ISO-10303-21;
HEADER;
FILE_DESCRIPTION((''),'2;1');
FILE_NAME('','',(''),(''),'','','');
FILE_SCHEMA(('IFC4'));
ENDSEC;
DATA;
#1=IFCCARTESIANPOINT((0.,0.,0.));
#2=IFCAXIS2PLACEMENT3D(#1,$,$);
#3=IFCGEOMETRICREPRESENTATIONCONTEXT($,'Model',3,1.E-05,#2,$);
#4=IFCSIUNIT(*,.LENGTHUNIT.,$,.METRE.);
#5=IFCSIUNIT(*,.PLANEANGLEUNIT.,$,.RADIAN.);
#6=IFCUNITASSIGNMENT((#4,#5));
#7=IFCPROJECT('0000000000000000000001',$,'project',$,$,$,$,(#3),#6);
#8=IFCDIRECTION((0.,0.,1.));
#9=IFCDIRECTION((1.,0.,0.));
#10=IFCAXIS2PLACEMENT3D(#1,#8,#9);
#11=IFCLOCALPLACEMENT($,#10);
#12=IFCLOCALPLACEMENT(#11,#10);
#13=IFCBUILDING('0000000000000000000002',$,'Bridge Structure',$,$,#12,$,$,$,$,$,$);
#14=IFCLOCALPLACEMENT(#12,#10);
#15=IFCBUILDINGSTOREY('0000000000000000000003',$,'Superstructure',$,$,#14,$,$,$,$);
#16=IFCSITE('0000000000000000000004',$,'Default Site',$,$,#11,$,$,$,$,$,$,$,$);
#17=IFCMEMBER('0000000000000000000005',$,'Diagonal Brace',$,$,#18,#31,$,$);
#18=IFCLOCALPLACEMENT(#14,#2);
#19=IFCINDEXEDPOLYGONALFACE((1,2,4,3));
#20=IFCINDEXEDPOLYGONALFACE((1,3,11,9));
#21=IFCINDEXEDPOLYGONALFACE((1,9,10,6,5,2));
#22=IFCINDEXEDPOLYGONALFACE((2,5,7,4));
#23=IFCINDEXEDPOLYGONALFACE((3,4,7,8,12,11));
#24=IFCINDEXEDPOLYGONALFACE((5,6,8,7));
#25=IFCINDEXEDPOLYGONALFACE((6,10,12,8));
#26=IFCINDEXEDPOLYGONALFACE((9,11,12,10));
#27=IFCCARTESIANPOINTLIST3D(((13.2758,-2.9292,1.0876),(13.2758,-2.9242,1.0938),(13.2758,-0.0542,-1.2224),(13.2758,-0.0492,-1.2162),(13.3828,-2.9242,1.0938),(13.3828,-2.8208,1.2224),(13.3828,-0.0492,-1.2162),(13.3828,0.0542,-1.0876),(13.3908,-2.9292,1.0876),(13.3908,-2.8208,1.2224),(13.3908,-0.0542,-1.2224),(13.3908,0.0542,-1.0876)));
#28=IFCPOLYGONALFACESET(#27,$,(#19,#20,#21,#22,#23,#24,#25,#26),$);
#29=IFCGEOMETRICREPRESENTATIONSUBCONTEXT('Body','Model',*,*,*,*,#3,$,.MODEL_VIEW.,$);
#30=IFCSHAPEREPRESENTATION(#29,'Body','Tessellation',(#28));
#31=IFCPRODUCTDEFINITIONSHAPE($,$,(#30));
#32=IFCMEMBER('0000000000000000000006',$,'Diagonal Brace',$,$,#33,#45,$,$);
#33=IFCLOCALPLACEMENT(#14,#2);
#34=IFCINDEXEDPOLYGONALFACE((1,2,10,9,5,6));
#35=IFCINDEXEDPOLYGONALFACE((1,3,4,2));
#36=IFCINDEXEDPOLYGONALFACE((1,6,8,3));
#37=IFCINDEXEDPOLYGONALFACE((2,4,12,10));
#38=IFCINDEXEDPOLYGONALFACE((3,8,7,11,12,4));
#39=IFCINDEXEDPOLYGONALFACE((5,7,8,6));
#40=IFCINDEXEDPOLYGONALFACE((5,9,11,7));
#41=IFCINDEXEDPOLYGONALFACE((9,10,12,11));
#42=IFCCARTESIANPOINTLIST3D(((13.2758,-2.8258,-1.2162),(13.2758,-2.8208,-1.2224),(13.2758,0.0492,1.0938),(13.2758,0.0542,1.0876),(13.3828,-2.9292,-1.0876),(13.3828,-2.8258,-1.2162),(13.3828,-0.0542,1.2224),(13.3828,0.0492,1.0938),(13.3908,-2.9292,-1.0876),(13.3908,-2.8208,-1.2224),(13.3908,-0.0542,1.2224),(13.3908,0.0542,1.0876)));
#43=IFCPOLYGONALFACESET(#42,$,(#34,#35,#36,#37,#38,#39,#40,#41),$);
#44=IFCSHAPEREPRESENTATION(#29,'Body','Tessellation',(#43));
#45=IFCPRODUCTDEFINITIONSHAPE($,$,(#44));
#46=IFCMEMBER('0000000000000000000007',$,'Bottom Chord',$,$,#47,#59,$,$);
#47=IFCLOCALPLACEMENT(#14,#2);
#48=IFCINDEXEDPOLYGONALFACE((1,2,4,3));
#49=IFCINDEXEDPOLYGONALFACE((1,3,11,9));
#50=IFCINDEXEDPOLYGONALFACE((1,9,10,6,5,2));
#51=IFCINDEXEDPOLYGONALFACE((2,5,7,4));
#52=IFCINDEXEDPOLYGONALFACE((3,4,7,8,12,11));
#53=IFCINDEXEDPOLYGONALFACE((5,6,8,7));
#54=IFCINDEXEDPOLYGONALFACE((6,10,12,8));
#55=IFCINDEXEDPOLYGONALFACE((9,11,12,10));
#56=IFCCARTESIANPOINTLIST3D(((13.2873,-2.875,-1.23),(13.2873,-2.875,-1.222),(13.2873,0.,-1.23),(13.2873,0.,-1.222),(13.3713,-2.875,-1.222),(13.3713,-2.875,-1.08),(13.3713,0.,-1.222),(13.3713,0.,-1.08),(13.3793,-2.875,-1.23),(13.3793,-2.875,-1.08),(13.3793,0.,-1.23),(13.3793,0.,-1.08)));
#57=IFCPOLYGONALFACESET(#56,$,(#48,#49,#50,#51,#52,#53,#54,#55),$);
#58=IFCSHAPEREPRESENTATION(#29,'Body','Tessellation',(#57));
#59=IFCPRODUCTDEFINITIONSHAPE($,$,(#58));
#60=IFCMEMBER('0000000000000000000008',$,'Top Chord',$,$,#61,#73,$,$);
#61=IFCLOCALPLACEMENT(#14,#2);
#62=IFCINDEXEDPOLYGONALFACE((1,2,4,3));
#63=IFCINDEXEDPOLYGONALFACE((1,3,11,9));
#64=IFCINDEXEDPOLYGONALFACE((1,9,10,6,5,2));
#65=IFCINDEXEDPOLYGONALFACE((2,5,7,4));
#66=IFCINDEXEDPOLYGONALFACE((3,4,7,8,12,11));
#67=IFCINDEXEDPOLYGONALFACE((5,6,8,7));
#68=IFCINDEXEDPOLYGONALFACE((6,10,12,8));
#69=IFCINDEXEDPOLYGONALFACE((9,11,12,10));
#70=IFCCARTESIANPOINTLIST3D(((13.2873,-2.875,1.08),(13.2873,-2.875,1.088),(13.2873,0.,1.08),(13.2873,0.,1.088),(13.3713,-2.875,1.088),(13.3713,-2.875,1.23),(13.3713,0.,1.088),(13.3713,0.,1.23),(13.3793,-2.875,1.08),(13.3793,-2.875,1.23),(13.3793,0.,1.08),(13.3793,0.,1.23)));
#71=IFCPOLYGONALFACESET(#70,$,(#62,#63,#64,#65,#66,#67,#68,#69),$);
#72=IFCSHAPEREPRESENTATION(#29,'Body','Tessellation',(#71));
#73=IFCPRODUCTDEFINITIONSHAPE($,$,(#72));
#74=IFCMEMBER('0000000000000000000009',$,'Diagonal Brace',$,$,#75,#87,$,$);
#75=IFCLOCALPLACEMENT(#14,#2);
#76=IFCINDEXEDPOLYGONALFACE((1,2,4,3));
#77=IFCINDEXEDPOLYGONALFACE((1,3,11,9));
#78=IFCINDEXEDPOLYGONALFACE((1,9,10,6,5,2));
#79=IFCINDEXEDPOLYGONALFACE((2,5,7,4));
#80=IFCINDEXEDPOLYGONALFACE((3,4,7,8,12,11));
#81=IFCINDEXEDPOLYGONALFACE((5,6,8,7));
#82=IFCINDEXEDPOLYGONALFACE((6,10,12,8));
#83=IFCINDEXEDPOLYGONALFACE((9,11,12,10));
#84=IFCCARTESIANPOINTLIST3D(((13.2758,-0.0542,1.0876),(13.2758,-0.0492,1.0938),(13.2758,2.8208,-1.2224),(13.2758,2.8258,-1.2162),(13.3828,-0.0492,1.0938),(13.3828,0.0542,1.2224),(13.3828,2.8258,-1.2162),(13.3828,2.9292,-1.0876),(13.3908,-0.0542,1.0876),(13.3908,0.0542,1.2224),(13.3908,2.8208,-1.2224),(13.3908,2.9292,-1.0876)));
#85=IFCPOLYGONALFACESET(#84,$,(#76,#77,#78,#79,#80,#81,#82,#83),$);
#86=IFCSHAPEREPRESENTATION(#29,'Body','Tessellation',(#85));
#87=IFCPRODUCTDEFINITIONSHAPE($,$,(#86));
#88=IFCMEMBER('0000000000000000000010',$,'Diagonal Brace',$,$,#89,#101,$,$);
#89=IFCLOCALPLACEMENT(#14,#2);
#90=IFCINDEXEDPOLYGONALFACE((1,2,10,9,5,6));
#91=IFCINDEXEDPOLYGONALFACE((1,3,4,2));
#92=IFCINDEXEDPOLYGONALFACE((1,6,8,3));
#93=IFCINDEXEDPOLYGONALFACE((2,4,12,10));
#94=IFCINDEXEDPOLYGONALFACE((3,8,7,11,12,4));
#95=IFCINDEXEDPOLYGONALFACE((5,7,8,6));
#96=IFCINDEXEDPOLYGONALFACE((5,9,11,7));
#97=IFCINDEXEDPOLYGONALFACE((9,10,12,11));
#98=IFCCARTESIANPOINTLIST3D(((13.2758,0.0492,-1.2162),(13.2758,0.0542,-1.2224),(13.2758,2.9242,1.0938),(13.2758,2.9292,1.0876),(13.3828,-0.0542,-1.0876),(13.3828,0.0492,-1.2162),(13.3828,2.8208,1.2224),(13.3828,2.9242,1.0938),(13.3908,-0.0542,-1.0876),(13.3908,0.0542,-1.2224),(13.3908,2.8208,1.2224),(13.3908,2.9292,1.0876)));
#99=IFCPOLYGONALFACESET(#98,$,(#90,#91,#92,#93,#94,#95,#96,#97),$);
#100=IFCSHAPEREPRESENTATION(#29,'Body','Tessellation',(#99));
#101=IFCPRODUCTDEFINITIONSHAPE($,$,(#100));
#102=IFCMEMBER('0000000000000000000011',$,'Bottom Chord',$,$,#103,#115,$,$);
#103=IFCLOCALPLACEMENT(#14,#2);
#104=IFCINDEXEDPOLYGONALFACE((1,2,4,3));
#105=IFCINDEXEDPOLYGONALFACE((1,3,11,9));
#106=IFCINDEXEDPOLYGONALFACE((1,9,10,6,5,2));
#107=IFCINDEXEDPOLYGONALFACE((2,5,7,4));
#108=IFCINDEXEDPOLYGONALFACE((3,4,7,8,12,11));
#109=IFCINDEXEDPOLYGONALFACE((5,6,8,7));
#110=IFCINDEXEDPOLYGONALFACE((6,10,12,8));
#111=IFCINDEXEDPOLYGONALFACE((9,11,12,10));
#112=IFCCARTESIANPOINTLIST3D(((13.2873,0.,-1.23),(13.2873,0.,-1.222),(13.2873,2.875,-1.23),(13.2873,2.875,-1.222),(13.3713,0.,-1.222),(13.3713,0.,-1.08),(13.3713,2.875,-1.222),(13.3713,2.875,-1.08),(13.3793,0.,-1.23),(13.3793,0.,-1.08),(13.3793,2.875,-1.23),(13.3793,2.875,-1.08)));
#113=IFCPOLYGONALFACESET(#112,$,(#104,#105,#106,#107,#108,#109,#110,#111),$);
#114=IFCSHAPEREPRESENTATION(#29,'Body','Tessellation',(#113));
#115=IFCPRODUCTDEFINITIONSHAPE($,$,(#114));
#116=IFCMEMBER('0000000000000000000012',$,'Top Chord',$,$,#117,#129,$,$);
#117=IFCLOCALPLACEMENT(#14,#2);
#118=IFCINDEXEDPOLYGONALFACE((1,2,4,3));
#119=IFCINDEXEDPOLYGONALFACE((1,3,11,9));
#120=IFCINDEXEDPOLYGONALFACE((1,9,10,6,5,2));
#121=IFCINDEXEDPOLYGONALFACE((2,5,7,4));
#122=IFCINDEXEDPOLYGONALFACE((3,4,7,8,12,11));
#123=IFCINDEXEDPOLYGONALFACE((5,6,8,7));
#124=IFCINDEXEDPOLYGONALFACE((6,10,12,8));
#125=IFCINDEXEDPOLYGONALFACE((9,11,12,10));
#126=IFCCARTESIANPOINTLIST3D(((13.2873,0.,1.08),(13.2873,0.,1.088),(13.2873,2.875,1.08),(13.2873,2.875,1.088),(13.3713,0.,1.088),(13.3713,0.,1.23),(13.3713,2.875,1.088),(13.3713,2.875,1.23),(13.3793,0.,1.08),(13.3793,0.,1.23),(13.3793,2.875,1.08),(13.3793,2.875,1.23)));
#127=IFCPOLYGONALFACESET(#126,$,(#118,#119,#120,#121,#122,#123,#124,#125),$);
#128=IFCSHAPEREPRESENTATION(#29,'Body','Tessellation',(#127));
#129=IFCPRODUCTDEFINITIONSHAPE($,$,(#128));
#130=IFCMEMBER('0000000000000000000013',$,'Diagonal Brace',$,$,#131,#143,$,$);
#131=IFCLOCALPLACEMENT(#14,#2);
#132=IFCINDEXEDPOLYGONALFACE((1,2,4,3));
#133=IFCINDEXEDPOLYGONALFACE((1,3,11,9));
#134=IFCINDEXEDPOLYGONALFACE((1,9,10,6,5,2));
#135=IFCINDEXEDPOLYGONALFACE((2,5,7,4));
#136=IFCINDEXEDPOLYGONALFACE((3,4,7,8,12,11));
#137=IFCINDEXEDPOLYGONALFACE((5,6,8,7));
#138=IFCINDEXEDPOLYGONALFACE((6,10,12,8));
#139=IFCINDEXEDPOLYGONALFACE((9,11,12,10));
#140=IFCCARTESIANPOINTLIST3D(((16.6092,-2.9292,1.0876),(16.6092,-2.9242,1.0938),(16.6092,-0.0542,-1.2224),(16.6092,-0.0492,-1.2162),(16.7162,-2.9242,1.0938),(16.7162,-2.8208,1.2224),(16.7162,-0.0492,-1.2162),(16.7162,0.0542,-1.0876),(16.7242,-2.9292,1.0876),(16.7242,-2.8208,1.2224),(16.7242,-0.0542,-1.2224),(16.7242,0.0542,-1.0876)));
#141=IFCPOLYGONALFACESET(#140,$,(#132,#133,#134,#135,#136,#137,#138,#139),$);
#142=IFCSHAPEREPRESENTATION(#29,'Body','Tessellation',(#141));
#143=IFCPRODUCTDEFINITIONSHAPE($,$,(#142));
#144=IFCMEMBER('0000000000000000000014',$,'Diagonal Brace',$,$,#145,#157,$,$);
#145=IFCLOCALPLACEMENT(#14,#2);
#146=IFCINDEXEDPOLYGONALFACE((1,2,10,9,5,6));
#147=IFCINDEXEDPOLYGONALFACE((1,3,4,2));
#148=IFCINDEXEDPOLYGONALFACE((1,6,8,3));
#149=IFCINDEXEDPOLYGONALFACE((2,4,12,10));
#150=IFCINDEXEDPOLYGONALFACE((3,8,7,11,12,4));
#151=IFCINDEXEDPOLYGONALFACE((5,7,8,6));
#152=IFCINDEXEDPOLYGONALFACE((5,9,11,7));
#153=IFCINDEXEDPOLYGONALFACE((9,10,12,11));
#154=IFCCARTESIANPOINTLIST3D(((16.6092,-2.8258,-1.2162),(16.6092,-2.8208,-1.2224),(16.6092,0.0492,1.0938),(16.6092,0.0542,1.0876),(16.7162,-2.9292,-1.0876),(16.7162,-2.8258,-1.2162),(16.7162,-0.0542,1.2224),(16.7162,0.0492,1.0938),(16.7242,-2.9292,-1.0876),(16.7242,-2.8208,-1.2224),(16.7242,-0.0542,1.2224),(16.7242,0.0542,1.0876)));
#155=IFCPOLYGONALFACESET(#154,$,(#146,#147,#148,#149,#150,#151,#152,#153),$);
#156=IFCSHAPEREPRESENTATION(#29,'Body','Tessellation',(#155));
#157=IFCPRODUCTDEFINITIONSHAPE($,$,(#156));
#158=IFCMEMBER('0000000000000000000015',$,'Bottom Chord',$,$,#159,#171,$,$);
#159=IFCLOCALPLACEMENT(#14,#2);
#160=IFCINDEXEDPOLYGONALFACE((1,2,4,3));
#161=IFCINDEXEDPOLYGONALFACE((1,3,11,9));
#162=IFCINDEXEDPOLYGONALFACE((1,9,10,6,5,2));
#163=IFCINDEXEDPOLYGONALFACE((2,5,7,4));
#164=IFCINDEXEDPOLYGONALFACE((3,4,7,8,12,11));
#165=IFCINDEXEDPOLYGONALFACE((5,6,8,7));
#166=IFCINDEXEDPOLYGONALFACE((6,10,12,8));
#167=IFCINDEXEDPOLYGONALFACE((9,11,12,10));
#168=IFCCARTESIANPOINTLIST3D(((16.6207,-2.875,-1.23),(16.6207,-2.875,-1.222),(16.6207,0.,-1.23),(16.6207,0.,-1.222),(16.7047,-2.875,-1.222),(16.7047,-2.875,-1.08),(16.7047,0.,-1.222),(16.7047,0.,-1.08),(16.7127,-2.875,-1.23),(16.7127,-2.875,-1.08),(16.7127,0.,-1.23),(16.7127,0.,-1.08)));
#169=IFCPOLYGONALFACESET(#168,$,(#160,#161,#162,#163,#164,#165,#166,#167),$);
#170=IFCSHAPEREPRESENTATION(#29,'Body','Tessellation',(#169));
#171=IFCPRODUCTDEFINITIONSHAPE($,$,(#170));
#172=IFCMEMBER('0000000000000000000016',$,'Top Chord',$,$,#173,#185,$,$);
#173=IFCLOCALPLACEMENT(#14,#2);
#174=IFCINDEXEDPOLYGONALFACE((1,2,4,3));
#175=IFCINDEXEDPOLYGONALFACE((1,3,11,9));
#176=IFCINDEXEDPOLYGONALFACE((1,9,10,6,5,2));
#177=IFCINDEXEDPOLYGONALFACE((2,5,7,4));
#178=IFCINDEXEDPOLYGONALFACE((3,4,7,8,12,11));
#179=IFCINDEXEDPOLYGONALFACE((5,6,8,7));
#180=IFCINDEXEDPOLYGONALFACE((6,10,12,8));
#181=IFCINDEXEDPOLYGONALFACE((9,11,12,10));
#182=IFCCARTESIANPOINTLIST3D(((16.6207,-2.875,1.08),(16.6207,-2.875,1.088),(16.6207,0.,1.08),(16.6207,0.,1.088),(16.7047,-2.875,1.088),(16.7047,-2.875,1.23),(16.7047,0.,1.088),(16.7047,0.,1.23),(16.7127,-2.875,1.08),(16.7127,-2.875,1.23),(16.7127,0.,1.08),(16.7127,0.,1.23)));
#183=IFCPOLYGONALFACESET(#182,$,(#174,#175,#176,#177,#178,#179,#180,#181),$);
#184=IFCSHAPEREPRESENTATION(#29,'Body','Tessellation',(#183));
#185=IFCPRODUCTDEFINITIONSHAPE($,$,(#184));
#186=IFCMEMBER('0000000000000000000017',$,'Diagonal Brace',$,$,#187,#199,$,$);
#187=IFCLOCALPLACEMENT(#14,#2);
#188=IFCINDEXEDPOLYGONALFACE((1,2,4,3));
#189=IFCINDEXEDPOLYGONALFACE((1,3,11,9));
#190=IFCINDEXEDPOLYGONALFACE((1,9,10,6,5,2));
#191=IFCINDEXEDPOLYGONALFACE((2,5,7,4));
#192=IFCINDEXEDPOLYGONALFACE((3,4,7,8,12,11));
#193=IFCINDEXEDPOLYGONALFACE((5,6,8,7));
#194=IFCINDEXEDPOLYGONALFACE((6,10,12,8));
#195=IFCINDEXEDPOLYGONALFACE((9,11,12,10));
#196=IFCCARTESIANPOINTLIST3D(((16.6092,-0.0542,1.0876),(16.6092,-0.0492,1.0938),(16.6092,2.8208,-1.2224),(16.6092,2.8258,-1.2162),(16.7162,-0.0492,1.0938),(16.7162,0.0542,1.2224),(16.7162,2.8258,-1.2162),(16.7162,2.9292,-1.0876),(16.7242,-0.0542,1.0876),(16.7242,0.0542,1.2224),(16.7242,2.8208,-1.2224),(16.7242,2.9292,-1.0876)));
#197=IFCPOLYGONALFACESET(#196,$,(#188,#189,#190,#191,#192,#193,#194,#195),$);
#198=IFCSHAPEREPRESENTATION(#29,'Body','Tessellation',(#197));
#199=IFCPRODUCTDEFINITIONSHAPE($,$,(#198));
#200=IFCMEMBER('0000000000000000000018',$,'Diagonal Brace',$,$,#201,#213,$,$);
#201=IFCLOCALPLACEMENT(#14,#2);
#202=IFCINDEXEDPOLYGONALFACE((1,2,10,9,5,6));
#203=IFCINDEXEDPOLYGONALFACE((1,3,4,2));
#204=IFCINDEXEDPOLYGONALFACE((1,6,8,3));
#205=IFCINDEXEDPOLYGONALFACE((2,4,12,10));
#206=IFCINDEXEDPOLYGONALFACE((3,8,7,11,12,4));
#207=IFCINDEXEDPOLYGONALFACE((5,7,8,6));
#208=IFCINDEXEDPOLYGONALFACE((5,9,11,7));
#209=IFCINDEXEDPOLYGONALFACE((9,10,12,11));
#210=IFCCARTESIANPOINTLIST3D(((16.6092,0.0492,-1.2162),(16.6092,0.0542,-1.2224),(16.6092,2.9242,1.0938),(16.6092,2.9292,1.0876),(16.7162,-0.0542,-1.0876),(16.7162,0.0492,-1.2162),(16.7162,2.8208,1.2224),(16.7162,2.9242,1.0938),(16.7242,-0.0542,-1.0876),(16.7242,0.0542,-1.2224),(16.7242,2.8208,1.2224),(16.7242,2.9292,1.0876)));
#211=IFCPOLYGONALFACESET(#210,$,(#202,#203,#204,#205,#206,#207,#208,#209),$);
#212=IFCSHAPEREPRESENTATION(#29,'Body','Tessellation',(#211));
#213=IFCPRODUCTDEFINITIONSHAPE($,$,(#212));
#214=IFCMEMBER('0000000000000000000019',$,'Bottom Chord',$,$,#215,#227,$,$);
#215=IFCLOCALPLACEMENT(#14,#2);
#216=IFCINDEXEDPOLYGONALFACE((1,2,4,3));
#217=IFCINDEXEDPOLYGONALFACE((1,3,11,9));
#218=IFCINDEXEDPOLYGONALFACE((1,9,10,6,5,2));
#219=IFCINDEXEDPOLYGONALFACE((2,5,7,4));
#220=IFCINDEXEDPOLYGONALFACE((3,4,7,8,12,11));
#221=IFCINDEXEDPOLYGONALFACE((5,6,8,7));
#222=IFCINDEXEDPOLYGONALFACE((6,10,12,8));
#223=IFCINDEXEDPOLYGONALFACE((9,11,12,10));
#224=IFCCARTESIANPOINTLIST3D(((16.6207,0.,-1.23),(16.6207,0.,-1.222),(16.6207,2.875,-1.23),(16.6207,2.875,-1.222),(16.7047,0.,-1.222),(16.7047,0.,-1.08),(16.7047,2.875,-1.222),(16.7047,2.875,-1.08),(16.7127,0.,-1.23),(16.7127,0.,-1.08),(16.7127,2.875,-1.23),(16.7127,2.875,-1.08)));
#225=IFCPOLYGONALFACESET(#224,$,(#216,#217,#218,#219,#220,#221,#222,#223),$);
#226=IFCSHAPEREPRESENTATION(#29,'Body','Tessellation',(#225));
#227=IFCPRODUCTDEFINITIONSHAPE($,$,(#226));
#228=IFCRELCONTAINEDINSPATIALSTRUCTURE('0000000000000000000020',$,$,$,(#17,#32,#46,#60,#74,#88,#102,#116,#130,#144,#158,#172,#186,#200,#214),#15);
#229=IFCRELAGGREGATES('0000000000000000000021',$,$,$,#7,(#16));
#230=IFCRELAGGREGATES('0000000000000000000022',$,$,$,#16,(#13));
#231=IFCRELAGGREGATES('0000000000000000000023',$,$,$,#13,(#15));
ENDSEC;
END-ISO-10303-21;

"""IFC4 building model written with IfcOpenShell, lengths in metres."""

from ifc_helpers import new_model, si_unit, frame, origin, origin_with_axes, origin_2d_with_axis, place, context, subcontext, project, spatial, l_section, extrude, element, save


model = new_model("IFC4")

# Units and contexts
model_context = context("Model", 3, precision=1e-05, world=origin())
body_context = subcontext(model_context, "Body", "Model", "MODEL_VIEW")
ifc_project = project(units=[si_unit("LENGTHUNIT", "METRE"), si_unit("PLANEANGLEUNIT", "RADIAN")], contexts=[model_context])

# Site, building, storey
site_placement = place(None, origin_with_axes())
site = spatial("IfcSite", under=ifc_project, at=site_placement, Name="Default Site")
building_placement = place(site_placement, origin_with_axes())
building = spatial("IfcBuilding", under=site, at=building_placement, Name="Bridge Structure")
storey_placement = place(building_placement, origin_with_axes())
storey = spatial("IfcBuildingStorey", under=building, at=storey_placement, Name="Superstructure")

# Members
for number, where, z_axis, x_axis, name in (
    (1, (13.3333, -2.875, 1.155), (0.0, 0.779544, -0.626347), (-1.0, 0.0, 0.0), "Diagonal Brace"),
    (2, (13.3333, -2.875, -1.155), (0.0, 0.779544, 0.626347), (-1.0, 0.0, 0.0), "Diagonal Brace"),
):
    element("IfcMember", number, at=place(storey_placement, frame(where, z_axis=z_axis, x_axis=x_axis)), inside=storey, Name=name, context=body_context, shape_type="SweptSolid", body=[
        extrude(l_section(Depth=0.173, Width=0.115, Thickness=0.008, at=origin_2d_with_axis()), origin_with_axes(), (0.0, 0.0, 1.0), 3.6881),
    ])
for number, where, z_axis, x_axis, name in (
    (3, (13.3333, -2.875, -1.155), (0.0, 1.0, 0.0), (-1.0, 0.0, 0.0), "Bottom Chord"),
    (4, (13.3333, -2.875, 1.155), (0.0, 1.0, 0.0), (-1.0, 0.0, 0.0), "Top Chord"),
):
    element("IfcMember", number, at=place(storey_placement, frame(where, z_axis=z_axis, x_axis=x_axis)), inside=storey, Name=name, context=body_context, shape_type="SweptSolid", body=[
        extrude(l_section(Depth=0.15, Width=0.092, Thickness=0.008, at=origin_2d_with_axis()), origin_with_axes(), (0.0, 0.0, 1.0), 2.875),
    ])
for number, where, z_axis, x_axis, name in (
    (5, (13.3333, 0.0, 1.155), (0.0, 0.779544, -0.626347), (-1.0, 0.0, 0.0), "Diagonal Brace"),
    (6, (13.3333, 0.0, -1.155), (0.0, 0.779544, 0.626347), (-1.0, 0.0, 0.0), "Diagonal Brace"),
):
    element("IfcMember", number, at=place(storey_placement, frame(where, z_axis=z_axis, x_axis=x_axis)), inside=storey, Name=name, context=body_context, shape_type="SweptSolid", body=[
        extrude(l_section(Depth=0.173, Width=0.115, Thickness=0.008, at=origin_2d_with_axis()), origin_with_axes(), (0.0, 0.0, 1.0), 3.6881),
    ])
for number, where, z_axis, x_axis, name in (
    (7, (13.3333, 0.0, -1.155), (0.0, 1.0, 0.0), (-1.0, 0.0, 0.0), "Bottom Chord"),
    (8, (13.3333, 0.0, 1.155), (0.0, 1.0, 0.0), (-1.0, 0.0, 0.0), "Top Chord"),
):
    element("IfcMember", number, at=place(storey_placement, frame(where, z_axis=z_axis, x_axis=x_axis)), inside=storey, Name=name, context=body_context, shape_type="SweptSolid", body=[
        extrude(l_section(Depth=0.15, Width=0.092, Thickness=0.008, at=origin_2d_with_axis()), origin_with_axes(), (0.0, 0.0, 1.0), 2.875),
    ])
for number, where, z_axis, x_axis, name in (
    (9, (16.6667, -2.875, 1.155), (0.0, 0.779544, -0.626347), (-1.0, 0.0, 0.0), "Diagonal Brace"),
    (10, (16.6667, -2.875, -1.155), (0.0, 0.779544, 0.626347), (-1.0, 0.0, 0.0), "Diagonal Brace"),
):
    element("IfcMember", number, at=place(storey_placement, frame(where, z_axis=z_axis, x_axis=x_axis)), inside=storey, Name=name, context=body_context, shape_type="SweptSolid", body=[
        extrude(l_section(Depth=0.173, Width=0.115, Thickness=0.008, at=origin_2d_with_axis()), origin_with_axes(), (0.0, 0.0, 1.0), 3.6881),
    ])
for number, where, z_axis, x_axis, name in (
    (11, (16.6667, -2.875, -1.155), (0.0, 1.0, 0.0), (-1.0, 0.0, 0.0), "Bottom Chord"),
    (12, (16.6667, -2.875, 1.155), (0.0, 1.0, 0.0), (-1.0, 0.0, 0.0), "Top Chord"),
):
    element("IfcMember", number, at=place(storey_placement, frame(where, z_axis=z_axis, x_axis=x_axis)), inside=storey, Name=name, context=body_context, shape_type="SweptSolid", body=[
        extrude(l_section(Depth=0.15, Width=0.092, Thickness=0.008, at=origin_2d_with_axis()), origin_with_axes(), (0.0, 0.0, 1.0), 2.875),
    ])
for number, where, z_axis, x_axis, name in (
    (13, (16.6667, 0.0, 1.155), (0.0, 0.779544, -0.626347), (-1.0, 0.0, 0.0), "Diagonal Brace"),
    (14, (16.6667, 0.0, -1.155), (0.0, 0.779544, 0.626347), (-1.0, 0.0, 0.0), "Diagonal Brace"),
):
    element("IfcMember", number, at=place(storey_placement, frame(where, z_axis=z_axis, x_axis=x_axis)), inside=storey, Name=name, context=body_context, shape_type="SweptSolid", body=[
        extrude(l_section(Depth=0.173, Width=0.115, Thickness=0.008, at=origin_2d_with_axis()), origin_with_axes(), (0.0, 0.0, 1.0), 3.6881),
    ])
for number, where, z_axis, x_axis, name in (
    (15, (16.6667, 0.0, -1.155), (0.0, 1.0, 0.0), (-1.0, 0.0, 0.0), "Bottom Chord"),
):
    element("IfcMember", number, at=place(storey_placement, frame(where, z_axis=z_axis, x_axis=x_axis)), inside=storey, Name=name, context=body_context, shape_type="SweptSolid", body=[
        extrude(l_section(Depth=0.15, Width=0.092, Thickness=0.008, at=origin_2d_with_axis()), origin_with_axes(), (0.0, 0.0, 1.0), 2.875),
    ])

save(model, "model.ifc")
